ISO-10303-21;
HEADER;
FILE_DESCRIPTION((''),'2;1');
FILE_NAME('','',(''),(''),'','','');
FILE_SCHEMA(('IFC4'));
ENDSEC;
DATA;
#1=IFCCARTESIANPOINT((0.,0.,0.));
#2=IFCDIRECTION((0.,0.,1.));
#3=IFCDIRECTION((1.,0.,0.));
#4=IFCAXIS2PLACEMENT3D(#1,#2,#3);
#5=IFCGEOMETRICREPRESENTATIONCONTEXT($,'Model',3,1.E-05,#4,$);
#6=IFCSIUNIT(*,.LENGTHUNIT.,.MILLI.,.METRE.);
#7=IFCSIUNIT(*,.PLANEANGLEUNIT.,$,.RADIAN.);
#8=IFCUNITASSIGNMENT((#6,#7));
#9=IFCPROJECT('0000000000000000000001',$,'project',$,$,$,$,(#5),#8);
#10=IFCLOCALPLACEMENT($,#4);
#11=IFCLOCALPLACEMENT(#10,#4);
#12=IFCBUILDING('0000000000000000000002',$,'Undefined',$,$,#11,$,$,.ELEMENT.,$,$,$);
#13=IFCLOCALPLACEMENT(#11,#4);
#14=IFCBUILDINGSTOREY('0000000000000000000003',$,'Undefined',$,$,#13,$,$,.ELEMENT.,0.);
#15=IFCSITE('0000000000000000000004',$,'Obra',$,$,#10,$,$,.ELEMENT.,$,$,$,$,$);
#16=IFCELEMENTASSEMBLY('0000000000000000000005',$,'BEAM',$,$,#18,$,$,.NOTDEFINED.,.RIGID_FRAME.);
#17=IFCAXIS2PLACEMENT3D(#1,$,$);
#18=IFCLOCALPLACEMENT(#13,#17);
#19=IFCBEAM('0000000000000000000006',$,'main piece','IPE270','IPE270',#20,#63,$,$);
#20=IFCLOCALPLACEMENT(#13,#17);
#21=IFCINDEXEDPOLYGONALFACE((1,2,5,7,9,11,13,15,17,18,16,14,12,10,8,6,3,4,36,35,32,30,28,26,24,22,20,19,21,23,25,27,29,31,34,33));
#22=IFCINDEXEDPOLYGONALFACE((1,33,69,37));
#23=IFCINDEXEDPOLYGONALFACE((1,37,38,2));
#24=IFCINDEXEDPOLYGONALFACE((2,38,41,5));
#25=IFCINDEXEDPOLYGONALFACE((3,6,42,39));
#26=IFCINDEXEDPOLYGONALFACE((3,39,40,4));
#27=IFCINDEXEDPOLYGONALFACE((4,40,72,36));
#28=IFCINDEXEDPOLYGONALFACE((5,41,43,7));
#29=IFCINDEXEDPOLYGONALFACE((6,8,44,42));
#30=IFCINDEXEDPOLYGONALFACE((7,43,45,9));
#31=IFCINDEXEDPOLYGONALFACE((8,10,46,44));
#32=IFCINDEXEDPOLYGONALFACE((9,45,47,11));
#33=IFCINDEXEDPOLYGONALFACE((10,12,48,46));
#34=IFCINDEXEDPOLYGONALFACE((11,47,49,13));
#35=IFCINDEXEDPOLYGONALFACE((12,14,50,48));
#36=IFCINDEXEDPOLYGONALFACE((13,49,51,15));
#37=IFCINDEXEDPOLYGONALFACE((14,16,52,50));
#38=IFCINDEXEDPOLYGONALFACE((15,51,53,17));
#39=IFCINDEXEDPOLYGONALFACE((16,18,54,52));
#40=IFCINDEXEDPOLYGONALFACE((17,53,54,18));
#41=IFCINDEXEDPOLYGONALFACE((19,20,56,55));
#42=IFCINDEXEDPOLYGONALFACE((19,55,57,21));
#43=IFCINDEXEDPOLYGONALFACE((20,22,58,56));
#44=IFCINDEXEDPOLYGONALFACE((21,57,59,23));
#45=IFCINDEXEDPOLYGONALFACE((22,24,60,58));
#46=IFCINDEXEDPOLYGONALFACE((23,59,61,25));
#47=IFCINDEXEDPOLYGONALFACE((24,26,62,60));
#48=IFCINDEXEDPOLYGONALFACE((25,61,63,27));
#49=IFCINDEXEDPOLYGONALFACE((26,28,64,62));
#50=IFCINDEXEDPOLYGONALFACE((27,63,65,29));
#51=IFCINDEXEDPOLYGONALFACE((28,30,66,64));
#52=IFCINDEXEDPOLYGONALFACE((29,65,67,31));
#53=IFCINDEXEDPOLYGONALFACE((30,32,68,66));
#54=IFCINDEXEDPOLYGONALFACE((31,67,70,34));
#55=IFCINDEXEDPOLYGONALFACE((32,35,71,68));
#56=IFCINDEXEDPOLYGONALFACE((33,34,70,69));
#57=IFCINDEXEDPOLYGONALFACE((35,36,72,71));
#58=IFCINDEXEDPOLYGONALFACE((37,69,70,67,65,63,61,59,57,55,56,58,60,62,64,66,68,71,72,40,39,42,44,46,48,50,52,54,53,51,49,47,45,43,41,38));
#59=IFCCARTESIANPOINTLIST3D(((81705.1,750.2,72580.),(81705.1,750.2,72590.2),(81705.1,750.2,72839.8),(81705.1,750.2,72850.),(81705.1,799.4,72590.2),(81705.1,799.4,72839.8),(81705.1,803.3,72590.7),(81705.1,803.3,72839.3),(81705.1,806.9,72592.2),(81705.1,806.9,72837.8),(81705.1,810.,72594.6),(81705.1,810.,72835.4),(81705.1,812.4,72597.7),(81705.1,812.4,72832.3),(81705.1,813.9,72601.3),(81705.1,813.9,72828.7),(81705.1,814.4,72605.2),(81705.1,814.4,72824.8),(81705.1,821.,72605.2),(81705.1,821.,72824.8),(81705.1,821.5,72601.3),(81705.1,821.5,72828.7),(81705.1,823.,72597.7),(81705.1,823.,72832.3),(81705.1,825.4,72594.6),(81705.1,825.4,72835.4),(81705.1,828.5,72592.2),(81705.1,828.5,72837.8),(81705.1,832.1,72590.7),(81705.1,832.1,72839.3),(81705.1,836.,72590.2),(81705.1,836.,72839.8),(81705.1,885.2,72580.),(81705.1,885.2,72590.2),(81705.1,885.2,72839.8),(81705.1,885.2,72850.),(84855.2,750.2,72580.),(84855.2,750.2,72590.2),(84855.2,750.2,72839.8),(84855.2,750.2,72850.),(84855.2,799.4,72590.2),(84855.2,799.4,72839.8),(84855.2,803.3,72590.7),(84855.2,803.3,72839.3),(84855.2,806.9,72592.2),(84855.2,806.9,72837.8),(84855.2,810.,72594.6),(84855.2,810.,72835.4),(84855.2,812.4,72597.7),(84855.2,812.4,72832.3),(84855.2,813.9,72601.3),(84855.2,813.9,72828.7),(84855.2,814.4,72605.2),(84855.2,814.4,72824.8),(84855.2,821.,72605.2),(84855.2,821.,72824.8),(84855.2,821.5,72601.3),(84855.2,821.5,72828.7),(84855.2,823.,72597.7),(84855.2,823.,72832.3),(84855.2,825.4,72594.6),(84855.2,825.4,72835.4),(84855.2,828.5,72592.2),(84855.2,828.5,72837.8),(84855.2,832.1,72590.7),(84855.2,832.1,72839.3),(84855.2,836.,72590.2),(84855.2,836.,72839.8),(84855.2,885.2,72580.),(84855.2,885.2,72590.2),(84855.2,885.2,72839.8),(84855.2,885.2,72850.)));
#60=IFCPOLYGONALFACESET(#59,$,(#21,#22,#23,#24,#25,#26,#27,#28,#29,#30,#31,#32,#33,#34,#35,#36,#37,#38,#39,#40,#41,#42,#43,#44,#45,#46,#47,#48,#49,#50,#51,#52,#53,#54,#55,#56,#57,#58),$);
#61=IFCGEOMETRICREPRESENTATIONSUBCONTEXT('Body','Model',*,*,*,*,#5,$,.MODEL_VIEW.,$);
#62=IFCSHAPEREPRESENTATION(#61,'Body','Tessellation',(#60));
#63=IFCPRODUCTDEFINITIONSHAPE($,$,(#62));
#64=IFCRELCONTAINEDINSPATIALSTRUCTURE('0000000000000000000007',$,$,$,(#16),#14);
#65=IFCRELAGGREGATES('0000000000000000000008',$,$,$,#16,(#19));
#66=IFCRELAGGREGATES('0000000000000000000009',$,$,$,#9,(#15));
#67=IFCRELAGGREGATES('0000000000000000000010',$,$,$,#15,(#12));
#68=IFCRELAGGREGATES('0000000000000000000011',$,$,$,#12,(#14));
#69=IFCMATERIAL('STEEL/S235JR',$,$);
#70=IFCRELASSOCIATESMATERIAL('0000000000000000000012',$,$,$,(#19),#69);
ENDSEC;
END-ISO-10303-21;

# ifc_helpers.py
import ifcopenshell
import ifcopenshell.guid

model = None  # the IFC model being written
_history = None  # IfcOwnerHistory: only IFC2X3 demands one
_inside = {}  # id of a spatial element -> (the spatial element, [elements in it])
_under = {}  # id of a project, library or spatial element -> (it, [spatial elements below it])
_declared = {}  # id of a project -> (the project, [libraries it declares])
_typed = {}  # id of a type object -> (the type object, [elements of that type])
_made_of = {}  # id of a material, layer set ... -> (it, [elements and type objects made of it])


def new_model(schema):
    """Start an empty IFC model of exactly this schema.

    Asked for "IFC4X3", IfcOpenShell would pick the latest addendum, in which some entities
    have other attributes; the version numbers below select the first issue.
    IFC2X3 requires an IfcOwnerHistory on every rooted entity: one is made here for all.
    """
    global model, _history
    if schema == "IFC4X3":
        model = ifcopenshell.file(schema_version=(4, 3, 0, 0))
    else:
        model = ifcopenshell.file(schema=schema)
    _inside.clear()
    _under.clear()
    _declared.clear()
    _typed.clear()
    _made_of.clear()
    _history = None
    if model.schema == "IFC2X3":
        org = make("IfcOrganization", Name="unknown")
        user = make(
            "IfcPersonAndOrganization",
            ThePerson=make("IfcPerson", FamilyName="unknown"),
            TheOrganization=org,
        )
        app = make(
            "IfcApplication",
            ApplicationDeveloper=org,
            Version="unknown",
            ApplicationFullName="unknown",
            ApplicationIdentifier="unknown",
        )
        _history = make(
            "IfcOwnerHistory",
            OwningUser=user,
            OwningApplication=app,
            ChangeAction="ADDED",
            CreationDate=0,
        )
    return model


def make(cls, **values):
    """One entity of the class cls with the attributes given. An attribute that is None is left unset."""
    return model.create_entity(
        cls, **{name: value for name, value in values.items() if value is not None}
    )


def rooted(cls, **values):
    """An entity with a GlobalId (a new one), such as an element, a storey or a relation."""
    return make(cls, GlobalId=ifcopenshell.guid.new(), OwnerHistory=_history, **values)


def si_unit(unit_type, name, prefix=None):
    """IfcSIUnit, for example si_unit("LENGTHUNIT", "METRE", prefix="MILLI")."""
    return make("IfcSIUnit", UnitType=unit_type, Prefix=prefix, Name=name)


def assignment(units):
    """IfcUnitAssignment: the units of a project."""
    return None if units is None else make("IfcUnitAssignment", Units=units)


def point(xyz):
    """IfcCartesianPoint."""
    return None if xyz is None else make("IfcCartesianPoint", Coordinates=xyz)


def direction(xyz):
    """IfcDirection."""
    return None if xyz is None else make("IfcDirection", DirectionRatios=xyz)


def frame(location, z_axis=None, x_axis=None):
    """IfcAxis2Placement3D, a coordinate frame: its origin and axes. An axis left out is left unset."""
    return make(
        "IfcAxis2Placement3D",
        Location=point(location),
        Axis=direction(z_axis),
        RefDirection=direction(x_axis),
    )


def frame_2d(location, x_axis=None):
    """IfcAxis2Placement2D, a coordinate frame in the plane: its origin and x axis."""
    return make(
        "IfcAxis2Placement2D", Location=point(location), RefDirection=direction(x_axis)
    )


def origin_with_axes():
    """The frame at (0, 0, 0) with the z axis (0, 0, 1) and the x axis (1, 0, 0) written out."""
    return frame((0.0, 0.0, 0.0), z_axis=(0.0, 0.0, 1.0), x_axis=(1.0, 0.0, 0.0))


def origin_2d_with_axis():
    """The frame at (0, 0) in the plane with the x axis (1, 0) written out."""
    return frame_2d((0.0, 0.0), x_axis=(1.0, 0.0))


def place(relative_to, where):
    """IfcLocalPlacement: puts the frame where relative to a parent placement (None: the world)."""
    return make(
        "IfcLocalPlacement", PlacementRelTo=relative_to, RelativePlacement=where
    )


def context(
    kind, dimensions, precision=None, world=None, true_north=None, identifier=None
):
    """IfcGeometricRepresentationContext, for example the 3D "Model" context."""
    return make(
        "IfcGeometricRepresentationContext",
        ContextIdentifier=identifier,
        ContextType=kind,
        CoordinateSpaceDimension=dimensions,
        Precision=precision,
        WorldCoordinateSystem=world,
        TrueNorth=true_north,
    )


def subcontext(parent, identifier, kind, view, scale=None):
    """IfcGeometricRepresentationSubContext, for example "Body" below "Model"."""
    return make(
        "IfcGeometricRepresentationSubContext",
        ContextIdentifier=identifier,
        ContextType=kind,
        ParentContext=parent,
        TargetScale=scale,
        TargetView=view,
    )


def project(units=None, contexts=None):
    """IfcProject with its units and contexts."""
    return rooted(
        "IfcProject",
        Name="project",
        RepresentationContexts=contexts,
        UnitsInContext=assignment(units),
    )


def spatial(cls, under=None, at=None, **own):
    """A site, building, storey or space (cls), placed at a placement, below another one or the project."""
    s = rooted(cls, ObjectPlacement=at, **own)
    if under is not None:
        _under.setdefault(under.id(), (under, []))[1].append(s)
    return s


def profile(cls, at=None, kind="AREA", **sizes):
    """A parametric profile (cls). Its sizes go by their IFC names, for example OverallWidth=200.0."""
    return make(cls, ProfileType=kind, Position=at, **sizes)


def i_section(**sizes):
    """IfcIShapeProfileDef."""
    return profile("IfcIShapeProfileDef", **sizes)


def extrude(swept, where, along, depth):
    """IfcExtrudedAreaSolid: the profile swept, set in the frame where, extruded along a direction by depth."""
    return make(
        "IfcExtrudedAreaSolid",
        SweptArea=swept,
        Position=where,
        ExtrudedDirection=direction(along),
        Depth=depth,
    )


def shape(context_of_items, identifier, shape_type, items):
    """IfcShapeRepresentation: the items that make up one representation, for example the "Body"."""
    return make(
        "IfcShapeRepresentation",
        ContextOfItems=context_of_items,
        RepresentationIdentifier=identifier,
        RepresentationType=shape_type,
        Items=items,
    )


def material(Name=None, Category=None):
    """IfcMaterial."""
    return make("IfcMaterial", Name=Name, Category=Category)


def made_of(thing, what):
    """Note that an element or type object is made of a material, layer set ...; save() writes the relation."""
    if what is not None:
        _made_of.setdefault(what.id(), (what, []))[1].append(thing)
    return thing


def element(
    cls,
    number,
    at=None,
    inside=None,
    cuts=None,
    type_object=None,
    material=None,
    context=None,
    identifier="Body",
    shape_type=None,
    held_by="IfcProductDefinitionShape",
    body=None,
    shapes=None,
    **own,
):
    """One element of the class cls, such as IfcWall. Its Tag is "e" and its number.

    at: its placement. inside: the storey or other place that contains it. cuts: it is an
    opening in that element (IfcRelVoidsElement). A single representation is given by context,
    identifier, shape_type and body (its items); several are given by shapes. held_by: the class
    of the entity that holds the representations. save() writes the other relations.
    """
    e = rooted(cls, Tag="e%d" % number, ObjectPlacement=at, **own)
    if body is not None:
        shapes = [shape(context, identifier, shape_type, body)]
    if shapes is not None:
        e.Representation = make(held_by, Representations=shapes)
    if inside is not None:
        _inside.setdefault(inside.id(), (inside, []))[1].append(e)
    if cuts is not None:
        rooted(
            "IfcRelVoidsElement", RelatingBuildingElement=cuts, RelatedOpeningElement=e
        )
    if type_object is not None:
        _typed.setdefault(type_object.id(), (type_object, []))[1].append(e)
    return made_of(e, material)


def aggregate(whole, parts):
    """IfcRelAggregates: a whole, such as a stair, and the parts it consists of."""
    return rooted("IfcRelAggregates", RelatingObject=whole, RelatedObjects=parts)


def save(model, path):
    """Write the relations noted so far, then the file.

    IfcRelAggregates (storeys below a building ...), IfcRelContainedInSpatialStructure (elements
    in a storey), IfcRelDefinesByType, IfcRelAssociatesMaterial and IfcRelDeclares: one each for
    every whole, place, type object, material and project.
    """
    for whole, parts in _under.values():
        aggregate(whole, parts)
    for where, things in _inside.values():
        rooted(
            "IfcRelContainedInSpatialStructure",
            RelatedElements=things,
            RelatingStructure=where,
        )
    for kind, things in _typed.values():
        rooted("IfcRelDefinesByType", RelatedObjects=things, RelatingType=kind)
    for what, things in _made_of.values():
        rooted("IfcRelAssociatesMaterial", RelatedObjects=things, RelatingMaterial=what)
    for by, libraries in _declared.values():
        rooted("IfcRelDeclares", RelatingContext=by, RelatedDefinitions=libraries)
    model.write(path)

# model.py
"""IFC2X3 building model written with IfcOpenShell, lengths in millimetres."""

from ifc_helpers import new_model, si_unit, frame, origin_with_axes, origin_2d_with_axis, place, context, subcontext, project, spatial, i_section, extrude, material, element, aggregate, save


model = new_model("IFC2X3")

# Units and contexts
model_context = context("Model", 3, precision=1e-05, world=origin_with_axes())
body_context = subcontext(model_context, "Body", "Model", "MODEL_VIEW")
ifc_project = project(units=[si_unit("LENGTHUNIT", "METRE", prefix="MILLI"), si_unit("PLANEANGLEUNIT", "RADIAN")], contexts=[model_context])

# Site, building, storey
site_placement = place(None, origin_with_axes())
site = spatial("IfcSite", under=ifc_project, at=site_placement, Name="Obra", CompositionType="ELEMENT")
building_placement = place(site_placement, origin_with_axes())
building = spatial("IfcBuilding", under=site, at=building_placement, Name="Undefined", CompositionType="ELEMENT")
storey_placement = place(building_placement, origin_with_axes())
storey = spatial("IfcBuildingStorey", under=building, at=storey_placement, Name="Undefined", CompositionType="ELEMENT", Elevation=0.0)

# Shared definitions
ifc_material = material(Name="STEEL/S235JR")

# Element assembly, beam
assembly_1_placement = place(storey_placement, origin_with_axes())
assembly_1 = element("IfcElementAssembly", 1, at=assembly_1_placement, inside=storey, Name="BEAM", AssemblyPlace="NOTDEFINED", PredefinedType="RIGID_FRAME")
beam_1_placement = place(assembly_1_placement, frame((81705.1, 817.7, 72715.0), z_axis=(0.0, 0.0, 1.0), x_axis=(1.0, 0.0, 0.0)))
beam_1 = element("IfcBeam", 2, at=beam_1_placement, material=ifc_material, Name="main piece", Description="IPE270", ObjectType="IPE270", context=body_context, shape_type="SweptSolid", body=[
    extrude(i_section(OverallWidth=135.0, OverallDepth=270.0, WebThickness=6.6, FlangeThickness=10.2, FilletRadius=15.0, at=origin_2d_with_axis()), frame((3150.0, 0.0, 0.0), z_axis=(-1.0, 0.0, 0.0), x_axis=(0.0, -1.0, 0.0)), (0.0, 0.0, 1.0), 3150.0),
])
aggregate(assembly_1, [beam_1])

save(model, "model.ifc")
